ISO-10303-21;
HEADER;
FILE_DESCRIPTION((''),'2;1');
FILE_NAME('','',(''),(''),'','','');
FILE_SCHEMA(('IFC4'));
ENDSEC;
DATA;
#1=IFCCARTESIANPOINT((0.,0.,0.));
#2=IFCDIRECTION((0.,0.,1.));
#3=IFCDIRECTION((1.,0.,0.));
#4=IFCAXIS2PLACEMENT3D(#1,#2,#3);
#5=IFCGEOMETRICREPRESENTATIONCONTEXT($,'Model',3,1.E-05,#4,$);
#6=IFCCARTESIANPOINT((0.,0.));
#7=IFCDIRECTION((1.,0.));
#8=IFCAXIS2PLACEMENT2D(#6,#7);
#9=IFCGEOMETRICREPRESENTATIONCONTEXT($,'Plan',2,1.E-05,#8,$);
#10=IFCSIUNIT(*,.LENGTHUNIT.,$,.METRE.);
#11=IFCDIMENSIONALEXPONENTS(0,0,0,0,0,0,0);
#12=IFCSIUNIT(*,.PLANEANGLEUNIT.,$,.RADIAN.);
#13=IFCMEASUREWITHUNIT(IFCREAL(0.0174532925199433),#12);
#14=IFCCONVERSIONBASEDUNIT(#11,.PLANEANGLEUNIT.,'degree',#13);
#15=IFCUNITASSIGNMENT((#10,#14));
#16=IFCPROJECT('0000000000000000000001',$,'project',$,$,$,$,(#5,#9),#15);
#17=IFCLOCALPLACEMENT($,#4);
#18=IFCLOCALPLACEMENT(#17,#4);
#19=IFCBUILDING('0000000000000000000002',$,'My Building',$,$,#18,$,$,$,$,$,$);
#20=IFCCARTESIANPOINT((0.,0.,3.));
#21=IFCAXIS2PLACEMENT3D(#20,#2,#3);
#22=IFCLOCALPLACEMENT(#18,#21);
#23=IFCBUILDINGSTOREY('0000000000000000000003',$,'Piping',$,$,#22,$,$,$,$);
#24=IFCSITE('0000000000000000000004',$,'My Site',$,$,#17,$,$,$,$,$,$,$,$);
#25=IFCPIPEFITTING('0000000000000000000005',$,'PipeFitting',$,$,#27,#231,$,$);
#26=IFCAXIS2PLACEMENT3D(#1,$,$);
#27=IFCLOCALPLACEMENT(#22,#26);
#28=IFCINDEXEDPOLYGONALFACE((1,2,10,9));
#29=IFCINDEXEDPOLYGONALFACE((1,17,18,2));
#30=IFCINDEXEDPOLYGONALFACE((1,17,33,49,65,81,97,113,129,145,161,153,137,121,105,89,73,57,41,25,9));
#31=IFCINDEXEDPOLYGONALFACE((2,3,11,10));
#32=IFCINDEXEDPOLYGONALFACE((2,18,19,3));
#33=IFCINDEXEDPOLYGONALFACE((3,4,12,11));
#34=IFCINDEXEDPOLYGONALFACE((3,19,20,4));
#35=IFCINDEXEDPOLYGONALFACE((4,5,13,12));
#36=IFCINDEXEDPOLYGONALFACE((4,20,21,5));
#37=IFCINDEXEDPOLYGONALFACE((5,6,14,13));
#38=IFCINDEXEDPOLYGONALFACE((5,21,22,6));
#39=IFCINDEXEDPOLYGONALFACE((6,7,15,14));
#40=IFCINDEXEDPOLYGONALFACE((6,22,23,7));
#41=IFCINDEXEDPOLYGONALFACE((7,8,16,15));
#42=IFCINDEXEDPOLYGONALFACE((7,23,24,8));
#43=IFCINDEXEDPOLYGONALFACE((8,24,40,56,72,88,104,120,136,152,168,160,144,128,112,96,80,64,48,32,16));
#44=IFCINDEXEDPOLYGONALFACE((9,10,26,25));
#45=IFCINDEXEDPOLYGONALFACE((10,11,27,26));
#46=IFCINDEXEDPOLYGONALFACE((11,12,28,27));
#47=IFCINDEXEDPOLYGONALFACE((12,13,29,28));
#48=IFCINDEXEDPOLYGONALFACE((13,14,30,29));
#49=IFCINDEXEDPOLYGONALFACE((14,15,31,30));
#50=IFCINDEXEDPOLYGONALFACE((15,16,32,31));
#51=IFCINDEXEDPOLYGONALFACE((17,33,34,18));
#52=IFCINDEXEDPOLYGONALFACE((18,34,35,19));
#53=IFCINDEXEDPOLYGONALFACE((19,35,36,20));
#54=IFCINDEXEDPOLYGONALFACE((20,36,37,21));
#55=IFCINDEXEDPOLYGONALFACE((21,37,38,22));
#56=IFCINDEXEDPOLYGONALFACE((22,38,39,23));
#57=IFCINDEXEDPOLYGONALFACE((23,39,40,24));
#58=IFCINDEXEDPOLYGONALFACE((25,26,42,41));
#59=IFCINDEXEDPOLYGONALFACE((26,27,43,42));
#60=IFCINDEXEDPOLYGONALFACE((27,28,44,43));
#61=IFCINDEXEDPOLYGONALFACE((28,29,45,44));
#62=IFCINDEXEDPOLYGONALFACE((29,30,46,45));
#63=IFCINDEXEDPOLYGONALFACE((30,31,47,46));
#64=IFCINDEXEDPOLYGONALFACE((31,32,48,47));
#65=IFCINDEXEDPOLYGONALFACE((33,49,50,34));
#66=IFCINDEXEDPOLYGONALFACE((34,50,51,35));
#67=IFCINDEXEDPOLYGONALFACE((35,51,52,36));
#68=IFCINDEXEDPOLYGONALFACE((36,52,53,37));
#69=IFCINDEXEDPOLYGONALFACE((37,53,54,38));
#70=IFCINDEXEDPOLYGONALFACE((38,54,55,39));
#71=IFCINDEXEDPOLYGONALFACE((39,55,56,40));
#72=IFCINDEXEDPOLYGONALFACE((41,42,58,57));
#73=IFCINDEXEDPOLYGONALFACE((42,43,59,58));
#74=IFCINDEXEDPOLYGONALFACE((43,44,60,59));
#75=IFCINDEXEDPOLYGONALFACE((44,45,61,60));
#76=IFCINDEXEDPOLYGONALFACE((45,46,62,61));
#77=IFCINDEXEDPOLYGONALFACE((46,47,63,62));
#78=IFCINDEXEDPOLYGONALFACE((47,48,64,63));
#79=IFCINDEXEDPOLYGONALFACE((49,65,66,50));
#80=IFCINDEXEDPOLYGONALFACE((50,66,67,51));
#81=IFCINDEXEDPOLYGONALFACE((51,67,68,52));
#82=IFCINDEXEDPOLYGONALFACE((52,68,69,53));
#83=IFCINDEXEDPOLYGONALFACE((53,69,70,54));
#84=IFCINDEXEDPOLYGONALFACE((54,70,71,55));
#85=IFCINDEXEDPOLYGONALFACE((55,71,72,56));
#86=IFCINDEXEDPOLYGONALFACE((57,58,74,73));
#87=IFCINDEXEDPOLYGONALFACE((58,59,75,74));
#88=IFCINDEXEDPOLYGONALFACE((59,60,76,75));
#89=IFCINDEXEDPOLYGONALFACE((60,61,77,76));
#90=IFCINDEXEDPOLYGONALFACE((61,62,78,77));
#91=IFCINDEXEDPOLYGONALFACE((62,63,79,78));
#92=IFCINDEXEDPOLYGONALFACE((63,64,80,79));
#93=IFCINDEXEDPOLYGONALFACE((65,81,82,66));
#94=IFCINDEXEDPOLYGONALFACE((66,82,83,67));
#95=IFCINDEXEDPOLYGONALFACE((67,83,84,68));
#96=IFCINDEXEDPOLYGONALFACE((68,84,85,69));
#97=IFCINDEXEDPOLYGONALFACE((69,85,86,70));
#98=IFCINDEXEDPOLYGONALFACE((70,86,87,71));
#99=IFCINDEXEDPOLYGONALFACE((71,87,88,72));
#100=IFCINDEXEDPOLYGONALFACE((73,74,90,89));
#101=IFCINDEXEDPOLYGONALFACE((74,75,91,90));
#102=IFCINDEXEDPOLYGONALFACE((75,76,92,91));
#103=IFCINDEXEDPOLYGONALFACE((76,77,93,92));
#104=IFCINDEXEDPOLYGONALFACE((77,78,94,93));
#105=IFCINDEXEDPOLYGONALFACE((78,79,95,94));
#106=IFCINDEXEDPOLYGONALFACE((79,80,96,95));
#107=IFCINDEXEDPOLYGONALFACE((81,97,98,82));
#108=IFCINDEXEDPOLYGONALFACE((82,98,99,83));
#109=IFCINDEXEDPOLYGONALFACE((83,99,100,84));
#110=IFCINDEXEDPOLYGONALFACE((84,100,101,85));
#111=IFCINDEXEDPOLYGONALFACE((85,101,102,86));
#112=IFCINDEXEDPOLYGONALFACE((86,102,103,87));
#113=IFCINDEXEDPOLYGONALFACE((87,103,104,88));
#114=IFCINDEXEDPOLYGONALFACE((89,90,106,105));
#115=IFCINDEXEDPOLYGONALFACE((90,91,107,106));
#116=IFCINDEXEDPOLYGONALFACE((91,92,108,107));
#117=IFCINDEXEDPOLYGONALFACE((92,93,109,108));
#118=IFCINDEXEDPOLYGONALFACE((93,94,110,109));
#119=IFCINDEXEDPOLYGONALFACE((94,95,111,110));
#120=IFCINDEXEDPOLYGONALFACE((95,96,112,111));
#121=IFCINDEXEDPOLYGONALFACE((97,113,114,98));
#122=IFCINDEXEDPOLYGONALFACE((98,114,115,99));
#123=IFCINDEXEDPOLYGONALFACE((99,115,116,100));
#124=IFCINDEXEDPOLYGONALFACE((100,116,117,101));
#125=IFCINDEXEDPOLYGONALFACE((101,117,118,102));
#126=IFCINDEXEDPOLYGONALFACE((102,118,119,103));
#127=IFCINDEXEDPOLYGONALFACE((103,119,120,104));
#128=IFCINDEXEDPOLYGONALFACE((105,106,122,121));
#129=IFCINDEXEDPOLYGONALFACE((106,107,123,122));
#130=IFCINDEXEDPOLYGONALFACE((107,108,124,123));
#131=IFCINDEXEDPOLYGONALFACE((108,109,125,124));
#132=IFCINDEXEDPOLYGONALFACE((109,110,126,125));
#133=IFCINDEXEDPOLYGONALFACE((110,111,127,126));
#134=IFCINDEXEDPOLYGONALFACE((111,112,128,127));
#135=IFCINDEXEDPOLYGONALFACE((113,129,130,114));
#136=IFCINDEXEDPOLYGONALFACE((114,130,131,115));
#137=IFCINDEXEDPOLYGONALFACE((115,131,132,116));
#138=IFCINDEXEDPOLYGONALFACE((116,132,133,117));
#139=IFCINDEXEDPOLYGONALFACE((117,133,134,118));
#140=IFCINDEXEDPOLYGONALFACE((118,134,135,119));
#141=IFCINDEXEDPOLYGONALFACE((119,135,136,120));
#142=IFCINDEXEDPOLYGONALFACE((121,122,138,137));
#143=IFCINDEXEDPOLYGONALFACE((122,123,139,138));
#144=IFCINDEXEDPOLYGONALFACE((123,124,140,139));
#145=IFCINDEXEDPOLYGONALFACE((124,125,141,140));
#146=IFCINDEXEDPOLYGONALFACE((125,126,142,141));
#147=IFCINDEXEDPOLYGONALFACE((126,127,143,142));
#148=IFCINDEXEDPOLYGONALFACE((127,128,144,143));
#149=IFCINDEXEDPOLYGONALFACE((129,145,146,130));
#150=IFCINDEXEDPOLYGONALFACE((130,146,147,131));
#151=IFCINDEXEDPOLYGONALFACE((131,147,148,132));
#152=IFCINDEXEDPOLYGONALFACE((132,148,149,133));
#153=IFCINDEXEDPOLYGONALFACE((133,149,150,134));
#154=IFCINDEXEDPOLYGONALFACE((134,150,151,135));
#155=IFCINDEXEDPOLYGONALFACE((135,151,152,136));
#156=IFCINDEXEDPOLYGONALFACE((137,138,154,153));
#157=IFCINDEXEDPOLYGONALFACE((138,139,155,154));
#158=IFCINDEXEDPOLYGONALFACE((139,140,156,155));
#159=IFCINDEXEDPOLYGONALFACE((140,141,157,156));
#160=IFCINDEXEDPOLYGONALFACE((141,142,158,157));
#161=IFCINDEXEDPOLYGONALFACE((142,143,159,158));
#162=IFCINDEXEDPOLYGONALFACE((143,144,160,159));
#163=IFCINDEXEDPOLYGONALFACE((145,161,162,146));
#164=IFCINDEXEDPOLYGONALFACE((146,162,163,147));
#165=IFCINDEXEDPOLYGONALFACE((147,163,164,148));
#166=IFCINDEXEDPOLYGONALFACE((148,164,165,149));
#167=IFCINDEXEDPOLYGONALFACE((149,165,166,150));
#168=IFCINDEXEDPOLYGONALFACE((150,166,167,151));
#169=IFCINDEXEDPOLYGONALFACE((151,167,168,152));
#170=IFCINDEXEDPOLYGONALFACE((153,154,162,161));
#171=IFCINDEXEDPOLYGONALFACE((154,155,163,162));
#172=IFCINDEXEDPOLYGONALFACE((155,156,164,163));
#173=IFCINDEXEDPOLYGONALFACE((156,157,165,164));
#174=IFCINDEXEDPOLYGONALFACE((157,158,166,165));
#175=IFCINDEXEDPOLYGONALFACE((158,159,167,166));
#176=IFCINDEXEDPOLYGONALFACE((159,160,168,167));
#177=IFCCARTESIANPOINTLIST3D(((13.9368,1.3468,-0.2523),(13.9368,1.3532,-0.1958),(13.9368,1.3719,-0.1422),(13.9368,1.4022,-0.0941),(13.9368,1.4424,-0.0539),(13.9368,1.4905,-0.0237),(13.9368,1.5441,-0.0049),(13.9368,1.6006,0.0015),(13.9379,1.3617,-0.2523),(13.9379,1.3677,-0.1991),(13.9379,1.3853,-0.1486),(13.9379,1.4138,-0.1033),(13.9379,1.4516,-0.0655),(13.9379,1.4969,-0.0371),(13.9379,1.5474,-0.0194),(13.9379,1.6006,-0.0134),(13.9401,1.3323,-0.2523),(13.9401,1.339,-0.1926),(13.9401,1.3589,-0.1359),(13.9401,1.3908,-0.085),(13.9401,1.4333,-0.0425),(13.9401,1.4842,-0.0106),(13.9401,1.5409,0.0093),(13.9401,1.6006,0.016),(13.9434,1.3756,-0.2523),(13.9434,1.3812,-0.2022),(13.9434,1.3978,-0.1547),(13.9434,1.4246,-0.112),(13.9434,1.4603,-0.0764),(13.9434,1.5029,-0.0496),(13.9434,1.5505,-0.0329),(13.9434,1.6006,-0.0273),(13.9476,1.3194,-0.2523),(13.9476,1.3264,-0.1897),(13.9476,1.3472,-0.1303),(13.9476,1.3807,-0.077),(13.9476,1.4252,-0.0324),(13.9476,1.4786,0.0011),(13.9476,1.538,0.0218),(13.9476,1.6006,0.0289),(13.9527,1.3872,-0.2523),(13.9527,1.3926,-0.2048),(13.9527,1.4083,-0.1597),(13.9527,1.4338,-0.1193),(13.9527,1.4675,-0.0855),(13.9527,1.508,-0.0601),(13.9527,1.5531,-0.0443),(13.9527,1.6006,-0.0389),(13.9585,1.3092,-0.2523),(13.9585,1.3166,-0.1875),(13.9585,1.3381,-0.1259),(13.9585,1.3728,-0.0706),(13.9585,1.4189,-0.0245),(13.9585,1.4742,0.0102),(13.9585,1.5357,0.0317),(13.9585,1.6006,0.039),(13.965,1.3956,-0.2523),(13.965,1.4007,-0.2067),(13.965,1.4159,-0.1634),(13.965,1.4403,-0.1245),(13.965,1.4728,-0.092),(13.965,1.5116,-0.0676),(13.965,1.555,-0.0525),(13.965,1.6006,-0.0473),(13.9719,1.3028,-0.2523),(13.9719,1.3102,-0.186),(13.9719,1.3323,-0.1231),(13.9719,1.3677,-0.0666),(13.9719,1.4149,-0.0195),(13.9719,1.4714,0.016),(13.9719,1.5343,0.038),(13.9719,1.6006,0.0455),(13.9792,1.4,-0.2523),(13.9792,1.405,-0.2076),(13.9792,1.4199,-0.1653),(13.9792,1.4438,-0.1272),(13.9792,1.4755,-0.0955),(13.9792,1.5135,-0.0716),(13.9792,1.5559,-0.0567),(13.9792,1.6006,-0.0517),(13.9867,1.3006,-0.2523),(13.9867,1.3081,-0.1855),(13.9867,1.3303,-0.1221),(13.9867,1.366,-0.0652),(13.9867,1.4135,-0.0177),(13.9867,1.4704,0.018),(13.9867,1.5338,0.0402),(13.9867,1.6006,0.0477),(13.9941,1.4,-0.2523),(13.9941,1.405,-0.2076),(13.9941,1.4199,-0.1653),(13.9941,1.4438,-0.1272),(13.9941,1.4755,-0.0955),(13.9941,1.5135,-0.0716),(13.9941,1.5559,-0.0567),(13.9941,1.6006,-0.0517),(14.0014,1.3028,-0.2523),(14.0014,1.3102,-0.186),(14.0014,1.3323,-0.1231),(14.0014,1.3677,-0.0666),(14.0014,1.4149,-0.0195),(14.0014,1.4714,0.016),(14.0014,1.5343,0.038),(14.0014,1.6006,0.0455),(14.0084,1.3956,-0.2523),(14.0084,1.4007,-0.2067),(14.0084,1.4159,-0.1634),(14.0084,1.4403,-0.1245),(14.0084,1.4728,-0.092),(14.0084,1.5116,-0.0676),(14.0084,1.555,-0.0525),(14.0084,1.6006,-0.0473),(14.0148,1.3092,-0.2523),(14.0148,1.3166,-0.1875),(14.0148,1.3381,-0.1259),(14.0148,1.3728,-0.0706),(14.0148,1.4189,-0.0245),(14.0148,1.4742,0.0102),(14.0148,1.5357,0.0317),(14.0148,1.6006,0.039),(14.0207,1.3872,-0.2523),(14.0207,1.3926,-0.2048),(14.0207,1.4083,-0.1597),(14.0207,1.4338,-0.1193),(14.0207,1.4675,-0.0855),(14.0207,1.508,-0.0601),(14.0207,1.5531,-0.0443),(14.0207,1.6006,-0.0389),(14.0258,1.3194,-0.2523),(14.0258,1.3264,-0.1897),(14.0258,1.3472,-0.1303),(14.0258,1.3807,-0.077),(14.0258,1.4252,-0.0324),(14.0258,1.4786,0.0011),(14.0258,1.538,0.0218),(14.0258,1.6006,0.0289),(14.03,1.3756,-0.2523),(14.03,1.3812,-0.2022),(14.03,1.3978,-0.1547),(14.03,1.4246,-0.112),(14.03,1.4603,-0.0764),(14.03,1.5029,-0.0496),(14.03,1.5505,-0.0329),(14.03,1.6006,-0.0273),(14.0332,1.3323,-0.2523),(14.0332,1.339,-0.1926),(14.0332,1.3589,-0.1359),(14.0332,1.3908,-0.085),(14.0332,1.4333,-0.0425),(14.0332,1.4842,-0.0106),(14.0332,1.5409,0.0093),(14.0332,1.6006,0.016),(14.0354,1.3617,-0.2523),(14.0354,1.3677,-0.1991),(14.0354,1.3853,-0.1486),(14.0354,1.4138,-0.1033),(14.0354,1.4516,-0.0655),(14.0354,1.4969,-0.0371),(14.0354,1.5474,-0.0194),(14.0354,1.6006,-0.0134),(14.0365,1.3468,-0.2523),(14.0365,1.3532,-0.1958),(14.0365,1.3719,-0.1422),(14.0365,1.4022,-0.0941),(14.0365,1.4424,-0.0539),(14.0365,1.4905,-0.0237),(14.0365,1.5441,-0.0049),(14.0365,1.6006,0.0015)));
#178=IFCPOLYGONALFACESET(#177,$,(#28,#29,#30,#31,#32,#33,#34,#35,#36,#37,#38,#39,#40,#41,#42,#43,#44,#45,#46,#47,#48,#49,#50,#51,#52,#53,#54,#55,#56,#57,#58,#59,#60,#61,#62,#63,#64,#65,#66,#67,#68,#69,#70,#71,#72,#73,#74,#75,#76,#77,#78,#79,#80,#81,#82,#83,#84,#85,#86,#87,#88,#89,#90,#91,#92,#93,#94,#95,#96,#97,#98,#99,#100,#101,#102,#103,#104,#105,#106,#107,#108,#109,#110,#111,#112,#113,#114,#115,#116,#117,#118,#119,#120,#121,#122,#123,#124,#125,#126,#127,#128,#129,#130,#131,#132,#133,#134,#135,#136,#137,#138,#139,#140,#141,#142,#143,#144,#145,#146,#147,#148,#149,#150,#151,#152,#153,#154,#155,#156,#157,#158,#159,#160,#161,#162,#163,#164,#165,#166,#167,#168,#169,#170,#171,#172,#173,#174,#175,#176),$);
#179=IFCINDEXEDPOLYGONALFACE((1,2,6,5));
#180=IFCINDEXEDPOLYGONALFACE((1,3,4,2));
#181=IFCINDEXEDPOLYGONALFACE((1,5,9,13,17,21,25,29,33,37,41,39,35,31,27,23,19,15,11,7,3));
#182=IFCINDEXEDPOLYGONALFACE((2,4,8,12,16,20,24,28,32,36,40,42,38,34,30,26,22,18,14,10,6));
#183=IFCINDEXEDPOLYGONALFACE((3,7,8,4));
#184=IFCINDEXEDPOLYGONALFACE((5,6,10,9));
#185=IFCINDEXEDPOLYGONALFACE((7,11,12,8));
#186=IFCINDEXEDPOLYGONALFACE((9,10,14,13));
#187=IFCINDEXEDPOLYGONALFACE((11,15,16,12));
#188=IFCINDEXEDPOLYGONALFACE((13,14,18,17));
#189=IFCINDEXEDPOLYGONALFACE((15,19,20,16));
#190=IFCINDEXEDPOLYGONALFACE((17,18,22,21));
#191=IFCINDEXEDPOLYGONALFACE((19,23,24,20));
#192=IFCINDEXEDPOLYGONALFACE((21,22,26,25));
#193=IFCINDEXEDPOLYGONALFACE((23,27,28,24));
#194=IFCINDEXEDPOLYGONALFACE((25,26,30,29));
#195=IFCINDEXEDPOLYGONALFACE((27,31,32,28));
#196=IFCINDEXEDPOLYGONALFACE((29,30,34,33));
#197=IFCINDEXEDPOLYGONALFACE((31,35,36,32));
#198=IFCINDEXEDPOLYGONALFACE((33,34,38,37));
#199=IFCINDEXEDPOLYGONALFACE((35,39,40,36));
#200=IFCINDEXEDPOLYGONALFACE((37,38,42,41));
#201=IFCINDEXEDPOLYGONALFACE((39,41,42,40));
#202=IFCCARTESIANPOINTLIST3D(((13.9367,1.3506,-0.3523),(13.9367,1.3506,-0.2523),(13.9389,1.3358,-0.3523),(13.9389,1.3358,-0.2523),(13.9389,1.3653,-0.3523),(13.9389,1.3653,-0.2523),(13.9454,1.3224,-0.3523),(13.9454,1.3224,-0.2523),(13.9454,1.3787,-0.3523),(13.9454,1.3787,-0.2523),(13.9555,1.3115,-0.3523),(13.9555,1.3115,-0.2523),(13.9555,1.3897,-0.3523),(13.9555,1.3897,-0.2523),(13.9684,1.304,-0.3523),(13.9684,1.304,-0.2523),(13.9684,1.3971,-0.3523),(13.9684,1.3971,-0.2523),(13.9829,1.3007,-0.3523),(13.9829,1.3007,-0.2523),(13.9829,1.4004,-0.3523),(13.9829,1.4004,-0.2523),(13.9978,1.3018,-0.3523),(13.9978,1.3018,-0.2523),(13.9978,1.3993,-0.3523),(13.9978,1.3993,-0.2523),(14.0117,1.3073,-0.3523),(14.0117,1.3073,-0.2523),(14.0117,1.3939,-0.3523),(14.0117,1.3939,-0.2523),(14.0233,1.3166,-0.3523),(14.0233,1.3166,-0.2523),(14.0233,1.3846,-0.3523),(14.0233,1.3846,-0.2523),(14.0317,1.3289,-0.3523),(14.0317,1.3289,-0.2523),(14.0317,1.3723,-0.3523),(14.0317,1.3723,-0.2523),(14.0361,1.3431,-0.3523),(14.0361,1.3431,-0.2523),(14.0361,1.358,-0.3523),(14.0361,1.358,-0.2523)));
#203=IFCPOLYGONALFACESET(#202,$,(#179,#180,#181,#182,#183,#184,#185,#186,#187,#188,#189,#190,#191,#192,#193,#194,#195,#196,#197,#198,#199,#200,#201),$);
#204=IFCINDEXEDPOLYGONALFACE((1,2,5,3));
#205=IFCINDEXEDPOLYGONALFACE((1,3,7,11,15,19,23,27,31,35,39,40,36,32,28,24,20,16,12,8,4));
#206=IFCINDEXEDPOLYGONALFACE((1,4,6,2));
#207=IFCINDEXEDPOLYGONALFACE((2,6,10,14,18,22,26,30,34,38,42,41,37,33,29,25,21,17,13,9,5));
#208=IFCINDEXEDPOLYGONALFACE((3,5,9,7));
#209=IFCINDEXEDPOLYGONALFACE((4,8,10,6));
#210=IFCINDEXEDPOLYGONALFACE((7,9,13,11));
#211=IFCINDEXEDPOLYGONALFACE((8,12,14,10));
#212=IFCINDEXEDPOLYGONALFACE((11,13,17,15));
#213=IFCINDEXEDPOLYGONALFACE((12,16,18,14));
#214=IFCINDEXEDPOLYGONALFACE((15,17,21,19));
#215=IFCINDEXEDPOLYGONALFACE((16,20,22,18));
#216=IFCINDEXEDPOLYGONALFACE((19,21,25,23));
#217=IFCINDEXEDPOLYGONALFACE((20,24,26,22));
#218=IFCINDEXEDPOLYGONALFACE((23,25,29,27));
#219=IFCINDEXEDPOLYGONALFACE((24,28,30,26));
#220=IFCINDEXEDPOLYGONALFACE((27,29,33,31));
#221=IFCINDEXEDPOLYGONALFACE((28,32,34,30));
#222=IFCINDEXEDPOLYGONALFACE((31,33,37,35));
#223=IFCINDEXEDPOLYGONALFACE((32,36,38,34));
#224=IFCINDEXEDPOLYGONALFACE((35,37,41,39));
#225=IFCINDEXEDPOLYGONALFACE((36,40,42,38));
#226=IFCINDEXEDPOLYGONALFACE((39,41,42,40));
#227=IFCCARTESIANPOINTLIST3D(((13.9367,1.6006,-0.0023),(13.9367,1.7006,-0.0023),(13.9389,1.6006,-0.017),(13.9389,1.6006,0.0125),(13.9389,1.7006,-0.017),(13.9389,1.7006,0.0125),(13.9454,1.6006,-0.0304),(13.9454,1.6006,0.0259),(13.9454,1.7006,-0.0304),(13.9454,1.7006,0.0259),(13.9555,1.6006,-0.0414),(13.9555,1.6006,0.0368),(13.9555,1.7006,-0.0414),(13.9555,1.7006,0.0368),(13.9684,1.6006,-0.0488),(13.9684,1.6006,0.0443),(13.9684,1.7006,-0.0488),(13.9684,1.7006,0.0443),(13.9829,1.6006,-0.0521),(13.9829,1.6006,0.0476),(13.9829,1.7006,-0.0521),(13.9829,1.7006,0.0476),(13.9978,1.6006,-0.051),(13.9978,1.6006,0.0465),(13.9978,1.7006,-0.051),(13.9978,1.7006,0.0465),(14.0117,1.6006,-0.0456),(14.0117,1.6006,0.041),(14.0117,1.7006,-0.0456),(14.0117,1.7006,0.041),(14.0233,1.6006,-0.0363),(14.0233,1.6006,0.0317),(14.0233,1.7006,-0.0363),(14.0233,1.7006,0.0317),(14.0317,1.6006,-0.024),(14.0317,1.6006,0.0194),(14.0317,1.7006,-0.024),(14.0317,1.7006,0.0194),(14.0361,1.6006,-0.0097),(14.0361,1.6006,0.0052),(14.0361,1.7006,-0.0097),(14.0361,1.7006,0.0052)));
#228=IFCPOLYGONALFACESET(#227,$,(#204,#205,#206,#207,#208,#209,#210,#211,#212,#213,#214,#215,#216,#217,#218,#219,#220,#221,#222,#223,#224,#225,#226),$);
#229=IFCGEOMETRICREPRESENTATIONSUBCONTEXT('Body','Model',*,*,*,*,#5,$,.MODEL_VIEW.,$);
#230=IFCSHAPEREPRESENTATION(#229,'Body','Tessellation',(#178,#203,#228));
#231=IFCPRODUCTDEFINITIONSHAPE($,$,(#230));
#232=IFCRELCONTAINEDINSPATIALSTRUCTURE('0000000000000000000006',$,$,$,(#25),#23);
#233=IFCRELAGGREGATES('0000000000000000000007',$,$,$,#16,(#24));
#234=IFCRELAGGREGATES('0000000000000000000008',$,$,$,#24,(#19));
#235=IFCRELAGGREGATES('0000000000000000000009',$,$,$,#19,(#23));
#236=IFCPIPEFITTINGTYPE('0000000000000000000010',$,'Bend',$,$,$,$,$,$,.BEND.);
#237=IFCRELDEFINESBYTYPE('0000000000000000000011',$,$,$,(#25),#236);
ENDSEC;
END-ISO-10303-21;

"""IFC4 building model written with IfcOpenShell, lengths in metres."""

from ifc_helpers import new_model, entity, si_unit, converted_unit, frame, origin_with_axes, origin_2d_with_axis, place, context, subcontext, project, spatial, circle, extrude, source, transform, mapped, type_object, type_shapes, element, save


model = new_model("IFC4")

# Units and contexts
model_context = context("Model", 3, precision=1e-05, world=origin_with_axes())
plan_context = context("Plan", 2, precision=1e-05, world=origin_2d_with_axis())
body_context = subcontext(model_context, "Body", "Model", "MODEL_VIEW")
ifc_project = project(units=[si_unit("LENGTHUNIT", "METRE"), converted_unit("PLANEANGLEUNIT", "degree", entity("IfcReal", 0.0174532925199433), si_unit("PLANEANGLEUNIT", "RADIAN"), dimensions=[0, 0, 0, 0, 0, 0, 0])], contexts=[model_context, plan_context])

# Site, building, storey
site_placement = place(None, origin_with_axes())
site = spatial("IfcSite", under=ifc_project, at=site_placement, Name="My Site")
building_placement = place(site_placement, origin_with_axes())
building = spatial("IfcBuilding", under=site, at=building_placement, Name="My Building")
storey_placement = place(building_placement, frame((0.0, 0.0, 3.0), z_axis=(0.0, 0.0, 1.0), x_axis=(1.0, 0.0, 0.0)))
storey = spatial("IfcBuildingStorey", under=building, at=storey_placement, Name="Piping")

# Pipe fitting
pipe_fitting_type_1 = type_object("IfcPipeFittingType", Name="Bend", PredefinedType="BEND")
shared_shape = source(origin_with_axes(), body_context, "Body", "SolidModel", [
    entity("IfcSweptDiskSolid", entity("IfcIndexedPolyCurve", entity("IfcCartesianPointList3D", [[0.0, 0.0, -0.1], [0.0, 0.0732, -0.2768], [0.0, 0.25, -0.35]]), [entity("IfcArcIndex", [1, 2, 3])]), 0.05),
    extrude(circle(Radius=0.05), origin_with_axes(), (0.0, 0.0, -1.0), 0.1),
    extrude(circle(Radius=0.05), frame((0.0, 0.25, -0.35), z_axis=(0.0, 1.0, 0.0), x_axis=(1.0, 0.0, 0.0)), (0.0, 0.0, 1.0), 0.1),
])
type_shapes(pipe_fitting_type_1, [shared_shape])
for number, where, z_axis, x_axis, name in (
    (1, (13.9867, 1.3506, -0.3523), (0.0, 0.0, -1.0), (-1.0, 0.0, 0.0), "PipeFitting"),
):
    element("IfcPipeFitting", number, at=place(storey_placement, frame(where, z_axis=z_axis, x_axis=x_axis)), inside=storey, type_object=pipe_fitting_type_1, Name=name, context=body_context, shape_type="MappedRepresentation", body=[
        mapped(shared_shape, transform((0.0, 0.0, 0.0), x_axis=(1.0, 0.0, 0.0), y_axis=(0.0, 1.0, 0.0), z_axis=(0.0, 0.0, 1.0), scale=1.0)),
    ])

save(model, "model.ifc")
